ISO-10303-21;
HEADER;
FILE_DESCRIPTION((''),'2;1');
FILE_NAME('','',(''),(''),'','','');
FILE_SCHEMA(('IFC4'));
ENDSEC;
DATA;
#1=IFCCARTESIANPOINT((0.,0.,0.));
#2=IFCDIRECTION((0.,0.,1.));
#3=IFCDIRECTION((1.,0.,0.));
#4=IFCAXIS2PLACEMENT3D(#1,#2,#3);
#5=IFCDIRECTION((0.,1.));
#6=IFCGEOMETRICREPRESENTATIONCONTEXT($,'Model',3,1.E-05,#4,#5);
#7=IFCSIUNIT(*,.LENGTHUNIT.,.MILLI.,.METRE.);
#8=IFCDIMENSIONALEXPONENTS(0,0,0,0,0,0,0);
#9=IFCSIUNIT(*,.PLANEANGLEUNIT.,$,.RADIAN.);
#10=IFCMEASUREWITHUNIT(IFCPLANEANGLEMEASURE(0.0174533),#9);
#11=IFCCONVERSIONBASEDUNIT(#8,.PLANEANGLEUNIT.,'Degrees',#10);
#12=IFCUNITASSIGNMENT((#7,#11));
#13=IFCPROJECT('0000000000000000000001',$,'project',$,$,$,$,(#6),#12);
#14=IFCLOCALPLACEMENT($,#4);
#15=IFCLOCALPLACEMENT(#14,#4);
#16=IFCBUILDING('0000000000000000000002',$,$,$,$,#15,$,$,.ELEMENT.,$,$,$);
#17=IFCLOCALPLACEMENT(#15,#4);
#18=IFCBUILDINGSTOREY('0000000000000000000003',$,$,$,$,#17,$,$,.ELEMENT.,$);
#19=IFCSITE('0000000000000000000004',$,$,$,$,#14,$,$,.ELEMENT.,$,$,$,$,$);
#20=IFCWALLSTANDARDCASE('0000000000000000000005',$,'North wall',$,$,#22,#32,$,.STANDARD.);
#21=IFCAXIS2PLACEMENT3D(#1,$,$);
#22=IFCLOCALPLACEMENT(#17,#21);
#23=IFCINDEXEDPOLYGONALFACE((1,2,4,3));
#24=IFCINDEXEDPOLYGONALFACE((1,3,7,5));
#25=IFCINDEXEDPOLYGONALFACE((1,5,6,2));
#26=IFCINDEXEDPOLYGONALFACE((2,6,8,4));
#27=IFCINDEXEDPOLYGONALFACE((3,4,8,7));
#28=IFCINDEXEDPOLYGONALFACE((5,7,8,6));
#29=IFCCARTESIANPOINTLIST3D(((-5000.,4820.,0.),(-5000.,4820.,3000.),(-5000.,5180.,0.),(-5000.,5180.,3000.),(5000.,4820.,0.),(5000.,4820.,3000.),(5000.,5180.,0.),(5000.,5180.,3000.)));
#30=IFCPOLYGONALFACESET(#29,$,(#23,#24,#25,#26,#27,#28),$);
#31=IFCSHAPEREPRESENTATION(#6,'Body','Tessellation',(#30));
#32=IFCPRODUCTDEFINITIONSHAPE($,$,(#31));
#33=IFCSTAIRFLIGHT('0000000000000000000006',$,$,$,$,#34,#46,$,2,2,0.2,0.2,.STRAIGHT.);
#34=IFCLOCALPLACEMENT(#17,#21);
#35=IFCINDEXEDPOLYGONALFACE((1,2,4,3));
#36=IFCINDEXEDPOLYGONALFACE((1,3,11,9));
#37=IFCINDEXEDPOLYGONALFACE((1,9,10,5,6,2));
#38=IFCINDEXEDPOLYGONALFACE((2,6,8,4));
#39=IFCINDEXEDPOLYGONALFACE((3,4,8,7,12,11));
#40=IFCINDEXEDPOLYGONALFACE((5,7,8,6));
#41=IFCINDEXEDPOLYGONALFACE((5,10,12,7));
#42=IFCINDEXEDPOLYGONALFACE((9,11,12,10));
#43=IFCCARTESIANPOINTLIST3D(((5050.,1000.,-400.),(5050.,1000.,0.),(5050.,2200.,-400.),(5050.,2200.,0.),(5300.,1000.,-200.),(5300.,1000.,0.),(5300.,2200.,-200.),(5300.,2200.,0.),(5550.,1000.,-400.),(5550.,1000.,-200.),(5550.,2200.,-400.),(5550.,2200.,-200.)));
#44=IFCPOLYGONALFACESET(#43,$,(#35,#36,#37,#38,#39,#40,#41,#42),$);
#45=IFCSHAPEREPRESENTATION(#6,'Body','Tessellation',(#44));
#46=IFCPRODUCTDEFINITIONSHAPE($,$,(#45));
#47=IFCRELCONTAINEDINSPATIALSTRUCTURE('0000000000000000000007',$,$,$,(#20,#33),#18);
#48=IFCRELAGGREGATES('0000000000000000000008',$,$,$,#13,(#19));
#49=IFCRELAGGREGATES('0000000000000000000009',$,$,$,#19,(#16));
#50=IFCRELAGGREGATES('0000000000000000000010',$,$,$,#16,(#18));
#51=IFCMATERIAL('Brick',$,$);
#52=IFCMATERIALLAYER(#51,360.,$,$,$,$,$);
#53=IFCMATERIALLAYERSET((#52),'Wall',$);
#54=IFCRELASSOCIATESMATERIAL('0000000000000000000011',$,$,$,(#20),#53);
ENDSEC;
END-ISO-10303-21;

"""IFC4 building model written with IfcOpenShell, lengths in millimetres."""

from ifc_helpers import new_model, entity, si_unit, converted_unit, direction, frame, origin_with_axes, place, context, project, spatial, polyline, outline, extrude, material, layer, layer_set, layer_usage, element, save


model = new_model("IFC4")

# Units and contexts
model_context = context("Model", 3, precision=1e-05, world=origin_with_axes(), true_north=direction((0.0, 1.0)))
ifc_project = project(units=[si_unit("LENGTHUNIT", "METRE", prefix="MILLI"), converted_unit("PLANEANGLEUNIT", "Degrees", entity("IfcPlaneAngleMeasure", 0.0174533), si_unit("PLANEANGLEUNIT", "RADIAN"), dimensions=[0, 0, 0, 0, 0, 0, 0])], contexts=[model_context])

# Site, building, storey
site_placement = place(None, origin_with_axes())
site = spatial("IfcSite", under=ifc_project, at=site_placement, CompositionType="ELEMENT")
building_placement = place(site_placement, origin_with_axes())
building = spatial("IfcBuilding", under=site, at=building_placement, CompositionType="ELEMENT")
storey_placement = place(building_placement, origin_with_axes())
storey = spatial("IfcBuildingStorey", under=building, at=storey_placement, CompositionType="ELEMENT")

# Shared definitions
ifc_material = material(Name="Brick")
ifc_layer = layer(ifc_material, 360.0)
ifc_layer_set = layer_set([ifc_layer], Name="Wall")
ifc_layer_usage = layer_usage(ifc_layer_set, "AXIS2", "POSITIVE", -180.0)

# Wall
wall_1_placement = place(storey_placement, frame((0.0, 5000.0, 0.0), z_axis=(0.0, 0.0, 1.0), x_axis=(1.0, 0.0, 0.0)))
element("IfcWallStandardCase", 1, at=wall_1_placement, inside=storey, material=ifc_layer_usage, Name="North wall", PredefinedType="STANDARD", context=model_context, shape_type="SweptSolid", body=[
    extrude(outline(polyline([(-5000.0, -180.0), (5000.0, -180.0), (5000.0, 180.0), (-5000.0, 180.0), (-5000.0, -180.0), (-5000.0, -180.0)])), origin_with_axes(), (0.0, 0.0, 1.0), 3000.0),
])

# Stair flight
stair_flight_placement = place(storey_placement, frame((5050.0, 1000.0, 0.0), z_axis=(0.0, 1.0, 0.0), x_axis=(1.0, 0.0, 0.0)))
element("IfcStairFlight", 2, at=stair_flight_placement, inside=storey, NumberOfRisers=2, NumberOfTreads=2, PredefinedType="STRAIGHT", RiserHeight=0.2, TreadLength=0.2, context=model_context, shape_type="SweptSolid", body=[
    extrude(outline(polyline([(0.0, 0.0), (250.0, 0.0), (250.0, 200.0), (500.0, 200.0), (500.0, 400.0), (0.0, 400.0), (0.0, 0.0)])), origin_with_axes(), (0.0, 0.0, 1.0), 1200.0),
])

save(model, "model.ifc")
